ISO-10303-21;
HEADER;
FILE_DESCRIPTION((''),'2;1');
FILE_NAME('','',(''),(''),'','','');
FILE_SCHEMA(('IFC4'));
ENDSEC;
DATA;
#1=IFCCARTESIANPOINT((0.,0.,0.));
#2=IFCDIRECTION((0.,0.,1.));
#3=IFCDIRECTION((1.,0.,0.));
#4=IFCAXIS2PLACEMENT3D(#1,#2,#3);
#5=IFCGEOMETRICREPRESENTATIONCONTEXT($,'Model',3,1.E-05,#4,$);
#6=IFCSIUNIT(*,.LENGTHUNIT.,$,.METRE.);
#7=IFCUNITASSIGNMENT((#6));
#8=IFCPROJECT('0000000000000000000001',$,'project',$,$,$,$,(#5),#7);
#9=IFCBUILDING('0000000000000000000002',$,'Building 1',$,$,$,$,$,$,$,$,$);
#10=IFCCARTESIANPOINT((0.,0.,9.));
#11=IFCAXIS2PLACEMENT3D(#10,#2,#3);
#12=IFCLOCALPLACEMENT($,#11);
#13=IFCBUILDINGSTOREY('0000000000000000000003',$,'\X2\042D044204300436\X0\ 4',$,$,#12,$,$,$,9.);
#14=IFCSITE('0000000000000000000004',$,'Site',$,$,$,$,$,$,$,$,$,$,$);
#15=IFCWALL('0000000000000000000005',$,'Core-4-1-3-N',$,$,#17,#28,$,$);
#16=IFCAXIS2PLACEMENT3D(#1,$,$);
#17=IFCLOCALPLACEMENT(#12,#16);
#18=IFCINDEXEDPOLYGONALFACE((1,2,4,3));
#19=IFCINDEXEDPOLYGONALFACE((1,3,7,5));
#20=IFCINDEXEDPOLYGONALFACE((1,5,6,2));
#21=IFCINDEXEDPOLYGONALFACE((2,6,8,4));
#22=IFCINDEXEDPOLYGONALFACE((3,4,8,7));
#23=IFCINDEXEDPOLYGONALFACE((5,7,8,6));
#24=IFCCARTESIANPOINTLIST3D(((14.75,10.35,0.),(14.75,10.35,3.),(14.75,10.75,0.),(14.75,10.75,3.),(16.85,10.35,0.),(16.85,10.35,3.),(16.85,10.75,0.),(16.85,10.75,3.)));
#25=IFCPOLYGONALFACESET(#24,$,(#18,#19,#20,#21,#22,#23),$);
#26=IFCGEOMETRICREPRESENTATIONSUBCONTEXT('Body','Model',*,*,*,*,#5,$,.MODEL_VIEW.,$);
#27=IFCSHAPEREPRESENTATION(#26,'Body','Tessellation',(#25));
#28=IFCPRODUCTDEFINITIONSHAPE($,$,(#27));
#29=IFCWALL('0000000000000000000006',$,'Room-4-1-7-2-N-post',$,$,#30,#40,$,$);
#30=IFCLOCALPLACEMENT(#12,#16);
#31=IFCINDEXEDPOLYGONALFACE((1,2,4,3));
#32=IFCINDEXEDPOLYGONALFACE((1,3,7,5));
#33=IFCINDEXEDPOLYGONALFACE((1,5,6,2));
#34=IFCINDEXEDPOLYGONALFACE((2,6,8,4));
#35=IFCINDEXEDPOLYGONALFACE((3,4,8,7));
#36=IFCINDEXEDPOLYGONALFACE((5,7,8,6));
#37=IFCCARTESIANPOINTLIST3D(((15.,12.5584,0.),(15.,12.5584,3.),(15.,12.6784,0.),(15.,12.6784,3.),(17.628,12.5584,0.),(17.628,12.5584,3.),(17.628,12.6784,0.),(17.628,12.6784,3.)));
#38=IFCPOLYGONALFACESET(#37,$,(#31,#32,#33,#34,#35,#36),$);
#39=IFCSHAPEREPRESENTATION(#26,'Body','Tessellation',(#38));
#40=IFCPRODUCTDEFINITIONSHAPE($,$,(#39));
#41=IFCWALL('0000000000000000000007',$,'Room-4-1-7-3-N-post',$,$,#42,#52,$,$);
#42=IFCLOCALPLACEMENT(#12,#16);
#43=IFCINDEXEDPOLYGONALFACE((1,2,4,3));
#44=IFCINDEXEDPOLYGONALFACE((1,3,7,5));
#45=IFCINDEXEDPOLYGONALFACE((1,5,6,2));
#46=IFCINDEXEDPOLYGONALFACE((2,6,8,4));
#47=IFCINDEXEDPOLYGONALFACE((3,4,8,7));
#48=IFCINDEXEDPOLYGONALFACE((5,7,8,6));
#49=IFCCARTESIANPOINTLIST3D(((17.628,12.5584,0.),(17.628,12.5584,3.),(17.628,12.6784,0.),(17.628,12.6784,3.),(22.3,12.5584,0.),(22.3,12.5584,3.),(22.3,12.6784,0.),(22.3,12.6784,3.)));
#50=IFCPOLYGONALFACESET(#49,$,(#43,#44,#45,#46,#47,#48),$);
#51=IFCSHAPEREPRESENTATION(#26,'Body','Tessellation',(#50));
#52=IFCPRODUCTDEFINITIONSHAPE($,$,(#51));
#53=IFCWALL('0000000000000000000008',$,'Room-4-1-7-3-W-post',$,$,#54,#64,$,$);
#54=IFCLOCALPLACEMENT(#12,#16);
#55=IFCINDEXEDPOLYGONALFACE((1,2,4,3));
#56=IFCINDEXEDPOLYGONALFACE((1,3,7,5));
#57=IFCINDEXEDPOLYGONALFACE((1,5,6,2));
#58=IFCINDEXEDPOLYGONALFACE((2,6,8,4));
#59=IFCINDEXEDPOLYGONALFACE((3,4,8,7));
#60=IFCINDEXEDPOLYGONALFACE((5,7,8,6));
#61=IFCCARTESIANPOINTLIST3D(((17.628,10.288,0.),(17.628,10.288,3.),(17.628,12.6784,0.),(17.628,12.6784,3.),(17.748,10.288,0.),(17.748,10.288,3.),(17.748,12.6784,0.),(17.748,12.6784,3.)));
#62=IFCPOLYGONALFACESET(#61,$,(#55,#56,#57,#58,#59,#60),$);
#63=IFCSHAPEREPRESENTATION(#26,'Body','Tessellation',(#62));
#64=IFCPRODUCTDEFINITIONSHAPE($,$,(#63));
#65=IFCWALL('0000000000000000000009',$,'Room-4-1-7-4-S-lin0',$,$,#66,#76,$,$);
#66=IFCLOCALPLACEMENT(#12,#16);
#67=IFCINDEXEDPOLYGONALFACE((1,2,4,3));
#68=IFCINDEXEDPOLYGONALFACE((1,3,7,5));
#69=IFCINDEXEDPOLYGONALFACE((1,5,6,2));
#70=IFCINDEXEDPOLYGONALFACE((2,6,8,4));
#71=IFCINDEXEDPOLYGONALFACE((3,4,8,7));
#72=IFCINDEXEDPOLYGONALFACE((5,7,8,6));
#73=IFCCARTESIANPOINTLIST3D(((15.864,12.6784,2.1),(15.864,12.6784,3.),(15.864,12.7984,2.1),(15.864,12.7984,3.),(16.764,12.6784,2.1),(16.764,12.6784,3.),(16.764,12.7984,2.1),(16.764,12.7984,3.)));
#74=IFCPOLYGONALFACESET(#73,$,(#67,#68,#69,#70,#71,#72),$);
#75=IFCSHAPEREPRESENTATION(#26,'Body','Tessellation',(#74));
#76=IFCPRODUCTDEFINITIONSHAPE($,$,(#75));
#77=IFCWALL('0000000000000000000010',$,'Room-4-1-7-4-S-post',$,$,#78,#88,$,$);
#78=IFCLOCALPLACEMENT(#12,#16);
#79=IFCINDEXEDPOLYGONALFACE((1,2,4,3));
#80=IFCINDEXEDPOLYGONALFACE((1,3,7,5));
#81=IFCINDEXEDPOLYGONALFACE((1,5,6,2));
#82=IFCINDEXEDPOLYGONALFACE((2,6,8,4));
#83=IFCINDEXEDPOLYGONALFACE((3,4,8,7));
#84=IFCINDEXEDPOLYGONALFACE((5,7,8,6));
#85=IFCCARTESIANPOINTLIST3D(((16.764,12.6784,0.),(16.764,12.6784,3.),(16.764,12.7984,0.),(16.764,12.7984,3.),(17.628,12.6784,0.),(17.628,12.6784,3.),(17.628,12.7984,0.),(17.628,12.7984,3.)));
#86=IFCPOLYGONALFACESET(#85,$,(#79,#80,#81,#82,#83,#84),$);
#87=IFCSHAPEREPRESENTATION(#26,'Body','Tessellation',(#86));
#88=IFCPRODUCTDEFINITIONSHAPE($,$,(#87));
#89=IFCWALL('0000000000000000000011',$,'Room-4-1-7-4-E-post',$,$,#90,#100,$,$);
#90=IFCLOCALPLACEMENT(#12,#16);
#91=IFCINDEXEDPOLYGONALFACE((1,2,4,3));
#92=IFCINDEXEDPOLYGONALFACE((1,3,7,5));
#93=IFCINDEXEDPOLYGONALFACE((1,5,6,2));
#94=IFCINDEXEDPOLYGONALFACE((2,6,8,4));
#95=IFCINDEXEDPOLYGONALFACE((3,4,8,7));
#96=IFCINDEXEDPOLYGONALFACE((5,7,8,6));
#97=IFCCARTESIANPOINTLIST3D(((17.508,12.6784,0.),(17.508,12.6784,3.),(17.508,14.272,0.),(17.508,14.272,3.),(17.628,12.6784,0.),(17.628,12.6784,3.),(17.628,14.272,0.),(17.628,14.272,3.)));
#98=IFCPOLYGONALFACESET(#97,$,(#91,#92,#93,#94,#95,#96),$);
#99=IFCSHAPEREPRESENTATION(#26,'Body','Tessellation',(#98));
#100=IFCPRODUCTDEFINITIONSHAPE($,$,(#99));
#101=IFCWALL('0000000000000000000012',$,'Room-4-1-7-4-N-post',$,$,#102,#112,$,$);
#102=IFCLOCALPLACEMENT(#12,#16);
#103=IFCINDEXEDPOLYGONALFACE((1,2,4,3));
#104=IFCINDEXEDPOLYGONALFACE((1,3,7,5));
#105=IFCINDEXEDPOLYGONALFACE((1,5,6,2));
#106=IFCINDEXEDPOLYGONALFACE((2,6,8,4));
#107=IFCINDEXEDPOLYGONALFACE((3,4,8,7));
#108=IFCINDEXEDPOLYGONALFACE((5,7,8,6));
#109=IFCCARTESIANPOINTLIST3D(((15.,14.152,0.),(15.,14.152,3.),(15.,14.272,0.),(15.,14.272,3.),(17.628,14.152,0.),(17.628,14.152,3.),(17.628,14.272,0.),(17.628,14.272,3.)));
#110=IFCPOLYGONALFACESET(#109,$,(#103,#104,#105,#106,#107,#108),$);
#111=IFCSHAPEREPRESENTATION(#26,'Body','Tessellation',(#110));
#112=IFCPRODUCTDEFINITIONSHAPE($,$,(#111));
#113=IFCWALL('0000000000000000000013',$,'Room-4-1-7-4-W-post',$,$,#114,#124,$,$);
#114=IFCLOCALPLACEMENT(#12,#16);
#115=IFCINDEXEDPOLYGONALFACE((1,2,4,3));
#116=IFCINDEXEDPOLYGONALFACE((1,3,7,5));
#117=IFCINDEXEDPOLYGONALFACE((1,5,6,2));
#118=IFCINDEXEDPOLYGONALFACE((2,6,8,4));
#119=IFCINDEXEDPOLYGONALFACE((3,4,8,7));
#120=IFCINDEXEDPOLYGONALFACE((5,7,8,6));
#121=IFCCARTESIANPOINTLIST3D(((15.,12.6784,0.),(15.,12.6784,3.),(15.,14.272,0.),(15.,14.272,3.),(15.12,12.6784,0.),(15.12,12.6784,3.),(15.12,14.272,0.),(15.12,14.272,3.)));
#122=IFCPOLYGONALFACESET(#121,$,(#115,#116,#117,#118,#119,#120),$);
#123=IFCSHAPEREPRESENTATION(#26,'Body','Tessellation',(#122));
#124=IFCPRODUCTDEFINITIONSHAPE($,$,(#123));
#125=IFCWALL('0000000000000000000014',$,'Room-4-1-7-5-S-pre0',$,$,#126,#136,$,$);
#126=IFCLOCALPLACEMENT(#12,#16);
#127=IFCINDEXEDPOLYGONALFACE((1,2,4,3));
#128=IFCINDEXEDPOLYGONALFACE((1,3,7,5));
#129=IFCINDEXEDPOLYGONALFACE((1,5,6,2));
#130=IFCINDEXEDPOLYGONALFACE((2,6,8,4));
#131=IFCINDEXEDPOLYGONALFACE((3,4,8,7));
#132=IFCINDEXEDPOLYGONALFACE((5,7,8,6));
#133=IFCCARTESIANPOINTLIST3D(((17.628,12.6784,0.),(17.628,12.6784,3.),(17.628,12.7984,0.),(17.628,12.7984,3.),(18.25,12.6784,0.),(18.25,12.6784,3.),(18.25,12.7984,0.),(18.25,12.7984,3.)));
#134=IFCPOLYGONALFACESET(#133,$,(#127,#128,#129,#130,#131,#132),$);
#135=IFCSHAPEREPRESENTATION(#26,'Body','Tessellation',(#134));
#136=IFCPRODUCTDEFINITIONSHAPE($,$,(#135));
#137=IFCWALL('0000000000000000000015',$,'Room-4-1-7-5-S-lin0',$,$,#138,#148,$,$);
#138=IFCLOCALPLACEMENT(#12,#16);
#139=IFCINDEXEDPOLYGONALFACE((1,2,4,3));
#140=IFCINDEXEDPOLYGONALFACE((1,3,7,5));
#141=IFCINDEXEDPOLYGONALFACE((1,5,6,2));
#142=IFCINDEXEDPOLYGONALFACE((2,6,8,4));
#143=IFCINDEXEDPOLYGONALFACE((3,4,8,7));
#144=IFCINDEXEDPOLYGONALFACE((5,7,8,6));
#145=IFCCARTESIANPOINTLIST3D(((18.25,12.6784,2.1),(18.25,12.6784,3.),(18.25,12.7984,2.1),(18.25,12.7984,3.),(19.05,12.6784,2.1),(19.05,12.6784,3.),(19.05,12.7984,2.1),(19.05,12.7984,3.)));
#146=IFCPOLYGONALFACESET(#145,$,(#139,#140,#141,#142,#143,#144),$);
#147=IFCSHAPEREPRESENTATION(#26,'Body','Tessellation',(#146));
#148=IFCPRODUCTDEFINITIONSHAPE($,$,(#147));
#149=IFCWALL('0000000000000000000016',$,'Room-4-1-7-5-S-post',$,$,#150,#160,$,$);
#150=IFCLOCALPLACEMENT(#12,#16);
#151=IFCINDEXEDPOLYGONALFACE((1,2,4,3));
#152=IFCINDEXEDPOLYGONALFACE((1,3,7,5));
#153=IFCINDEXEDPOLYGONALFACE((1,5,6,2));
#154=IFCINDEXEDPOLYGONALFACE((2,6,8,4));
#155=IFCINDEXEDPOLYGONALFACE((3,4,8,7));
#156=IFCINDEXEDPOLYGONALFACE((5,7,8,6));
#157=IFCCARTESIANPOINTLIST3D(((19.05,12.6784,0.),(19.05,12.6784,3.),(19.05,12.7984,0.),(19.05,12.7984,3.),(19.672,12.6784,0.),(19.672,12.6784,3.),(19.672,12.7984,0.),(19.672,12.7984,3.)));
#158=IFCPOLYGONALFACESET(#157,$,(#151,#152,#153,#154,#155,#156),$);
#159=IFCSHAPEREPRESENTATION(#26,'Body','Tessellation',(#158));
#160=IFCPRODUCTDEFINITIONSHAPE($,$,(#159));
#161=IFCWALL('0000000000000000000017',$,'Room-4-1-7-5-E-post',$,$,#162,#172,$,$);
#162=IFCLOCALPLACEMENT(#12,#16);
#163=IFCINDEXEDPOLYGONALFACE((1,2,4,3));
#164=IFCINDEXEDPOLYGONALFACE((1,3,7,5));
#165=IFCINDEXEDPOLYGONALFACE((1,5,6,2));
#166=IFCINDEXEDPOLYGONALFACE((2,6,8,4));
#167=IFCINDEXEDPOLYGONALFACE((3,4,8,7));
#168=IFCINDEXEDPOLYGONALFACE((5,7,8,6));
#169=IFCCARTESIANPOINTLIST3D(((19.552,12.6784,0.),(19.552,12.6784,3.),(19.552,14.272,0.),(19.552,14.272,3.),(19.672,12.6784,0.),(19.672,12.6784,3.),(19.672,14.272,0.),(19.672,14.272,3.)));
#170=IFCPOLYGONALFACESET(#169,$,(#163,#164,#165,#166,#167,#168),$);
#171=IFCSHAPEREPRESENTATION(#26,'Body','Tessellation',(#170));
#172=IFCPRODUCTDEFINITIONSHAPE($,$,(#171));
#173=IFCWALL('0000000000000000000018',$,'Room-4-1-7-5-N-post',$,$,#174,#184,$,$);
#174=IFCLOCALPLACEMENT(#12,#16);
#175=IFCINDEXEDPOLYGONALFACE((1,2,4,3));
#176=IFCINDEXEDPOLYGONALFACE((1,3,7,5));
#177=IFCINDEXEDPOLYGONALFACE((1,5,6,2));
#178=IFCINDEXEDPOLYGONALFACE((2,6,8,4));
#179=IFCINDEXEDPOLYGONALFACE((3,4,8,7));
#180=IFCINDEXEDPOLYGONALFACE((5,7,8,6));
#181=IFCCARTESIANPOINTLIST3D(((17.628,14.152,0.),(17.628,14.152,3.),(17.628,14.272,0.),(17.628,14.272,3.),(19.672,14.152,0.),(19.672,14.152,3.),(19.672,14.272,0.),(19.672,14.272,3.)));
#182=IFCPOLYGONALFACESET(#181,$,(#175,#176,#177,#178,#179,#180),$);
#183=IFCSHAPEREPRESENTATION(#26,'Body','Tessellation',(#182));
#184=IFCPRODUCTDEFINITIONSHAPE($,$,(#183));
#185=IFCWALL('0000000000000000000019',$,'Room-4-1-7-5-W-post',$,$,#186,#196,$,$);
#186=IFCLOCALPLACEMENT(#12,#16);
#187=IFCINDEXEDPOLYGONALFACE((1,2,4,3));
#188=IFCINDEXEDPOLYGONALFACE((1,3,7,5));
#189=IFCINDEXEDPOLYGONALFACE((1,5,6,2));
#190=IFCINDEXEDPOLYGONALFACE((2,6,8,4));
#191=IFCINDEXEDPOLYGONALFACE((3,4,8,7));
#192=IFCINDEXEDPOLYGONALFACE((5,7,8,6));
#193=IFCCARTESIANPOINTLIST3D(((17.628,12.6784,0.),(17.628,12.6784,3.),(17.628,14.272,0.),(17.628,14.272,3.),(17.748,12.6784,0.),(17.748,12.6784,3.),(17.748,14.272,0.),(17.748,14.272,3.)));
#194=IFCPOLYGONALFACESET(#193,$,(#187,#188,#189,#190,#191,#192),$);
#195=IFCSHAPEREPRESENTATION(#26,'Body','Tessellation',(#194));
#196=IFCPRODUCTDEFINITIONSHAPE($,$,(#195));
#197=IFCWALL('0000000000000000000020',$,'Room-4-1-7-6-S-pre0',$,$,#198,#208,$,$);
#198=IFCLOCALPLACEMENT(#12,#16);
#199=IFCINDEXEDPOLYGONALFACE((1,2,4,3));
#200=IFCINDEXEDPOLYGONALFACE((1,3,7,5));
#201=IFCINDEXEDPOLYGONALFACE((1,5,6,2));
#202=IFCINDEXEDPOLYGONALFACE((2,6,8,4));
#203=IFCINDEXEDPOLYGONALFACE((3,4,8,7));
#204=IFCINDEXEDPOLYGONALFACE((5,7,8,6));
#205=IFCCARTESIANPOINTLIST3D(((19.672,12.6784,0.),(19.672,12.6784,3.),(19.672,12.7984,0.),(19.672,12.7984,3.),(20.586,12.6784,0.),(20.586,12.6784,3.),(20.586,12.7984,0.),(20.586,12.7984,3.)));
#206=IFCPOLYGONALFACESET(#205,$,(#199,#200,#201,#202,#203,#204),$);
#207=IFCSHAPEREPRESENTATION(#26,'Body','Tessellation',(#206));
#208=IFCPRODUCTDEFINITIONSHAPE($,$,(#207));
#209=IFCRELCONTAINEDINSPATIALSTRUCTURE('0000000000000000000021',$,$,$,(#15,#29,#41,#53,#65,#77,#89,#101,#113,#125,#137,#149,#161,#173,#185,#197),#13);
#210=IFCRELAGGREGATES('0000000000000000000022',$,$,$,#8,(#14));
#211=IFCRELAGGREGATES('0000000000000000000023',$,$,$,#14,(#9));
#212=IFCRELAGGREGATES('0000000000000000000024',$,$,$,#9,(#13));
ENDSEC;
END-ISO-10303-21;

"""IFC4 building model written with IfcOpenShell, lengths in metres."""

from ifc_helpers import new_model, si_unit, frame, origin_with_axes, place, context, subcontext, project, spatial, indexed_curve, outline, extrude, element, save


model = new_model("IFC4")

# Units and contexts
model_context = context("Model", 3, precision=1e-05, world=origin_with_axes())
body_context = subcontext(model_context, "Body", "Model", "MODEL_VIEW")
ifc_project = project(units=[si_unit("LENGTHUNIT", "METRE")], contexts=[model_context])

# Site, building, storey
site = spatial("IfcSite", under=ifc_project, Name="Site")
building = spatial("IfcBuilding", under=site, Name="Building 1")
storey_placement = place(None, frame((0.0, 0.0, 9.0), z_axis=(0.0, 0.0, 1.0), x_axis=(1.0, 0.0, 0.0)))
storey = spatial("IfcBuildingStorey", under=building, at=storey_placement, Name="Этаж 4", Elevation=9.0)

# Walls
wall_1_placement = place(storey_placement, frame((16.85, 10.75, 0.0), z_axis=(0.0, 0.0, 1.0), x_axis=(-1.0, 0.0, 0.0)))
element("IfcWall", 1, at=wall_1_placement, inside=storey, Name="Core-4-1-3-N", context=body_context, shape_type="SweptSolid", body=[
    extrude(outline(indexed_curve([(0.0, 0.0), (0.0, 0.4), (2.1, 0.4), (2.1, 0.0), (0.0, 0.0)], self_intersect=False)), origin_with_axes(), (0.0, 0.0, 1.0), 3.0),
])
wall_2_placement = place(storey_placement, frame((17.628, 12.6784, 0.0), z_axis=(0.0, 0.0, 1.0), x_axis=(-1.0, 0.0, 0.0)))
element("IfcWall", 2, at=wall_2_placement, inside=storey, Name="Room-4-1-7-2-N-post", context=body_context, shape_type="SweptSolid", body=[
    extrude(outline(indexed_curve([(0.0, 0.0), (0.0, 0.12), (2.628, 0.12), (2.628, 0.0), (0.0, 0.0)], self_intersect=False)), origin_with_axes(), (0.0, 0.0, 1.0), 3.0),
])
wall_3_placement = place(storey_placement, frame((22.3, 12.6784, 0.0), z_axis=(0.0, 0.0, 1.0), x_axis=(-1.0, 0.0, 0.0)))
element("IfcWall", 3, at=wall_3_placement, inside=storey, Name="Room-4-1-7-3-N-post", context=body_context, shape_type="SweptSolid", body=[
    extrude(outline(indexed_curve([(0.0, 0.0), (0.0, 0.12), (4.672, 0.12), (4.672, 0.0), (0.0, 0.0)], self_intersect=False)), origin_with_axes(), (0.0, 0.0, 1.0), 3.0),
])
wall_4_placement = place(storey_placement, frame((17.628, 12.6784, 0.0), z_axis=(0.0, 0.0, 1.0), x_axis=(0.0, -1.0, 0.0)))
element("IfcWall", 4, at=wall_4_placement, inside=storey, Name="Room-4-1-7-3-W-post", context=body_context, shape_type="SweptSolid", body=[
    extrude(outline(indexed_curve([(0.0, 0.0), (0.0, 0.12), (2.3904, 0.12), (2.3904, 0.0), (0.0, 0.0)], self_intersect=False)), origin_with_axes(), (0.0, 0.0, 1.0), 3.0),
])
wall_5_placement = place(storey_placement, frame((15.864, 12.6784, 2.1), z_axis=(0.0, 0.0, 1.0), x_axis=(1.0, 0.0, 0.0)))
element("IfcWall", 5, at=wall_5_placement, inside=storey, Name="Room-4-1-7-4-S-lin0", context=body_context, shape_type="SweptSolid", body=[
    extrude(outline(indexed_curve([(0.0, 0.0), (0.0, 0.12), (0.9, 0.12), (0.9, 0.0), (0.0, 0.0)], self_intersect=False)), origin_with_axes(), (0.0, 0.0, 1.0), 0.9),
])
wall_6_placement = place(storey_placement, frame((16.764, 12.6784, 0.0), z_axis=(0.0, 0.0, 1.0), x_axis=(1.0, 0.0, 0.0)))
element("IfcWall", 6, at=wall_6_placement, inside=storey, Name="Room-4-1-7-4-S-post", context=body_context, shape_type="SweptSolid", body=[
    extrude(outline(indexed_curve([(0.0, 0.0), (0.0, 0.12), (0.864, 0.12), (0.864, 0.0), (0.0, 0.0)], self_intersect=False)), origin_with_axes(), (0.0, 0.0, 1.0), 3.0),
])
wall_7_placement = place(storey_placement, frame((17.628, 12.6784, 0.0), z_axis=(0.0, 0.0, 1.0), x_axis=(0.0, 1.0, 0.0)))
element("IfcWall", 7, at=wall_7_placement, inside=storey, Name="Room-4-1-7-4-E-post", context=body_context, shape_type="SweptSolid", body=[
    extrude(outline(indexed_curve([(0.0, 0.0), (0.0, 0.12), (1.5936, 0.12), (1.5936, 0.0), (0.0, 0.0)], self_intersect=False)), origin_with_axes(), (0.0, 0.0, 1.0), 3.0),
])
wall_8_placement = place(storey_placement, frame((17.628, 14.272, 0.0), z_axis=(0.0, 0.0, 1.0), x_axis=(-1.0, 0.0, 0.0)))
element("IfcWall", 8, at=wall_8_placement, inside=storey, Name="Room-4-1-7-4-N-post", context=body_context, shape_type="SweptSolid", body=[
    extrude(outline(indexed_curve([(0.0, 0.0), (0.0, 0.12), (2.628, 0.12), (2.628, 0.0), (0.0, 0.0)], self_intersect=False)), origin_with_axes(), (0.0, 0.0, 1.0), 3.0),
])
wall_9_placement = place(storey_placement, frame((15.0, 14.272, 0.0), z_axis=(0.0, 0.0, 1.0), x_axis=(0.0, -1.0, 0.0)))
element("IfcWall", 9, at=wall_9_placement, inside=storey, Name="Room-4-1-7-4-W-post", context=body_context, shape_type="SweptSolid", body=[
    extrude(outline(indexed_curve([(0.0, 0.0), (0.0, 0.12), (1.5936, 0.12), (1.5936, 0.0), (0.0, 0.0)], self_intersect=False)), origin_with_axes(), (0.0, 0.0, 1.0), 3.0),
])
wall_10_placement = place(storey_placement, frame((17.628, 12.6784, 0.0), z_axis=(0.0, 0.0, 1.0), x_axis=(1.0, 0.0, 0.0)))
element("IfcWall", 10, at=wall_10_placement, inside=storey, Name="Room-4-1-7-5-S-pre0", context=body_context, shape_type="SweptSolid", body=[
    extrude(outline(indexed_curve([(0.0, 0.0), (0.0, 0.12), (0.622, 0.12), (0.622, 0.0), (0.0, 0.0)], self_intersect=False)), origin_with_axes(), (0.0, 0.0, 1.0), 3.0),
])
wall_11_placement = place(storey_placement, frame((18.25, 12.6784, 2.1), z_axis=(0.0, 0.0, 1.0), x_axis=(1.0, 0.0, 0.0)))
element("IfcWall", 11, at=wall_11_placement, inside=storey, Name="Room-4-1-7-5-S-lin0", context=body_context, shape_type="SweptSolid", body=[
    extrude(outline(indexed_curve([(0.0, 0.0), (0.0, 0.12), (0.8, 0.12), (0.8, 0.0), (0.0, 0.0)], self_intersect=False)), origin_with_axes(), (0.0, 0.0, 1.0), 0.9),
])
wall_12_placement = place(storey_placement, frame((19.05, 12.6784, 0.0), z_axis=(0.0, 0.0, 1.0), x_axis=(1.0, 0.0, 0.0)))
element("IfcWall", 12, at=wall_12_placement, inside=storey, Name="Room-4-1-7-5-S-post", context=body_context, shape_type="SweptSolid", body=[
    extrude(outline(indexed_curve([(0.0, 0.0), (0.0, 0.12), (0.622, 0.12), (0.622, 0.0), (0.0, 0.0)], self_intersect=False)), origin_with_axes(), (0.0, 0.0, 1.0), 3.0),
])
wall_13_placement = place(storey_placement, frame((19.672, 12.6784, 0.0), z_axis=(0.0, 0.0, 1.0), x_axis=(0.0, 1.0, 0.0)))
element("IfcWall", 13, at=wall_13_placement, inside=storey, Name="Room-4-1-7-5-E-post", context=body_context, shape_type="SweptSolid", body=[
    extrude(outline(indexed_curve([(0.0, 0.0), (0.0, 0.12), (1.5936, 0.12), (1.5936, 0.0), (0.0, 0.0)], self_intersect=False)), origin_with_axes(), (0.0, 0.0, 1.0), 3.0),
])
wall_14_placement = place(storey_placement, frame((19.672, 14.272, 0.0), z_axis=(0.0, 0.0, 1.0), x_axis=(-1.0, 0.0, 0.0)))
element("IfcWall", 14, at=wall_14_placement, inside=storey, Name="Room-4-1-7-5-N-post", context=body_context, shape_type="SweptSolid", body=[
    extrude(outline(indexed_curve([(0.0, 0.0), (0.0, 0.12), (2.044, 0.12), (2.044, 0.0), (0.0, 0.0)], self_intersect=False)), origin_with_axes(), (0.0, 0.0, 1.0), 3.0),
])
wall_15_placement = place(storey_placement, frame((17.628, 14.272, 0.0), z_axis=(0.0, 0.0, 1.0), x_axis=(0.0, -1.0, 0.0)))
element("IfcWall", 15, at=wall_15_placement, inside=storey, Name="Room-4-1-7-5-W-post", context=body_context, shape_type="SweptSolid", body=[
    extrude(outline(indexed_curve([(0.0, 0.0), (0.0, 0.12), (1.5936, 0.12), (1.5936, 0.0), (0.0, 0.0)], self_intersect=False)), origin_with_axes(), (0.0, 0.0, 1.0), 3.0),
])
wall_16_placement = place(storey_placement, frame((19.672, 12.6784, 0.0), z_axis=(0.0, 0.0, 1.0), x_axis=(1.0, 0.0, 0.0)))
element("IfcWall", 16, at=wall_16_placement, inside=storey, Name="Room-4-1-7-6-S-pre0", context=body_context, shape_type="SweptSolid", body=[
    extrude(outline(indexed_curve([(0.0, 0.0), (0.0, 0.12), (0.914, 0.12), (0.914, 0.0), (0.0, 0.0)], self_intersect=False)), origin_with_axes(), (0.0, 0.0, 1.0), 3.0),
])

save(model, "model.ifc")
